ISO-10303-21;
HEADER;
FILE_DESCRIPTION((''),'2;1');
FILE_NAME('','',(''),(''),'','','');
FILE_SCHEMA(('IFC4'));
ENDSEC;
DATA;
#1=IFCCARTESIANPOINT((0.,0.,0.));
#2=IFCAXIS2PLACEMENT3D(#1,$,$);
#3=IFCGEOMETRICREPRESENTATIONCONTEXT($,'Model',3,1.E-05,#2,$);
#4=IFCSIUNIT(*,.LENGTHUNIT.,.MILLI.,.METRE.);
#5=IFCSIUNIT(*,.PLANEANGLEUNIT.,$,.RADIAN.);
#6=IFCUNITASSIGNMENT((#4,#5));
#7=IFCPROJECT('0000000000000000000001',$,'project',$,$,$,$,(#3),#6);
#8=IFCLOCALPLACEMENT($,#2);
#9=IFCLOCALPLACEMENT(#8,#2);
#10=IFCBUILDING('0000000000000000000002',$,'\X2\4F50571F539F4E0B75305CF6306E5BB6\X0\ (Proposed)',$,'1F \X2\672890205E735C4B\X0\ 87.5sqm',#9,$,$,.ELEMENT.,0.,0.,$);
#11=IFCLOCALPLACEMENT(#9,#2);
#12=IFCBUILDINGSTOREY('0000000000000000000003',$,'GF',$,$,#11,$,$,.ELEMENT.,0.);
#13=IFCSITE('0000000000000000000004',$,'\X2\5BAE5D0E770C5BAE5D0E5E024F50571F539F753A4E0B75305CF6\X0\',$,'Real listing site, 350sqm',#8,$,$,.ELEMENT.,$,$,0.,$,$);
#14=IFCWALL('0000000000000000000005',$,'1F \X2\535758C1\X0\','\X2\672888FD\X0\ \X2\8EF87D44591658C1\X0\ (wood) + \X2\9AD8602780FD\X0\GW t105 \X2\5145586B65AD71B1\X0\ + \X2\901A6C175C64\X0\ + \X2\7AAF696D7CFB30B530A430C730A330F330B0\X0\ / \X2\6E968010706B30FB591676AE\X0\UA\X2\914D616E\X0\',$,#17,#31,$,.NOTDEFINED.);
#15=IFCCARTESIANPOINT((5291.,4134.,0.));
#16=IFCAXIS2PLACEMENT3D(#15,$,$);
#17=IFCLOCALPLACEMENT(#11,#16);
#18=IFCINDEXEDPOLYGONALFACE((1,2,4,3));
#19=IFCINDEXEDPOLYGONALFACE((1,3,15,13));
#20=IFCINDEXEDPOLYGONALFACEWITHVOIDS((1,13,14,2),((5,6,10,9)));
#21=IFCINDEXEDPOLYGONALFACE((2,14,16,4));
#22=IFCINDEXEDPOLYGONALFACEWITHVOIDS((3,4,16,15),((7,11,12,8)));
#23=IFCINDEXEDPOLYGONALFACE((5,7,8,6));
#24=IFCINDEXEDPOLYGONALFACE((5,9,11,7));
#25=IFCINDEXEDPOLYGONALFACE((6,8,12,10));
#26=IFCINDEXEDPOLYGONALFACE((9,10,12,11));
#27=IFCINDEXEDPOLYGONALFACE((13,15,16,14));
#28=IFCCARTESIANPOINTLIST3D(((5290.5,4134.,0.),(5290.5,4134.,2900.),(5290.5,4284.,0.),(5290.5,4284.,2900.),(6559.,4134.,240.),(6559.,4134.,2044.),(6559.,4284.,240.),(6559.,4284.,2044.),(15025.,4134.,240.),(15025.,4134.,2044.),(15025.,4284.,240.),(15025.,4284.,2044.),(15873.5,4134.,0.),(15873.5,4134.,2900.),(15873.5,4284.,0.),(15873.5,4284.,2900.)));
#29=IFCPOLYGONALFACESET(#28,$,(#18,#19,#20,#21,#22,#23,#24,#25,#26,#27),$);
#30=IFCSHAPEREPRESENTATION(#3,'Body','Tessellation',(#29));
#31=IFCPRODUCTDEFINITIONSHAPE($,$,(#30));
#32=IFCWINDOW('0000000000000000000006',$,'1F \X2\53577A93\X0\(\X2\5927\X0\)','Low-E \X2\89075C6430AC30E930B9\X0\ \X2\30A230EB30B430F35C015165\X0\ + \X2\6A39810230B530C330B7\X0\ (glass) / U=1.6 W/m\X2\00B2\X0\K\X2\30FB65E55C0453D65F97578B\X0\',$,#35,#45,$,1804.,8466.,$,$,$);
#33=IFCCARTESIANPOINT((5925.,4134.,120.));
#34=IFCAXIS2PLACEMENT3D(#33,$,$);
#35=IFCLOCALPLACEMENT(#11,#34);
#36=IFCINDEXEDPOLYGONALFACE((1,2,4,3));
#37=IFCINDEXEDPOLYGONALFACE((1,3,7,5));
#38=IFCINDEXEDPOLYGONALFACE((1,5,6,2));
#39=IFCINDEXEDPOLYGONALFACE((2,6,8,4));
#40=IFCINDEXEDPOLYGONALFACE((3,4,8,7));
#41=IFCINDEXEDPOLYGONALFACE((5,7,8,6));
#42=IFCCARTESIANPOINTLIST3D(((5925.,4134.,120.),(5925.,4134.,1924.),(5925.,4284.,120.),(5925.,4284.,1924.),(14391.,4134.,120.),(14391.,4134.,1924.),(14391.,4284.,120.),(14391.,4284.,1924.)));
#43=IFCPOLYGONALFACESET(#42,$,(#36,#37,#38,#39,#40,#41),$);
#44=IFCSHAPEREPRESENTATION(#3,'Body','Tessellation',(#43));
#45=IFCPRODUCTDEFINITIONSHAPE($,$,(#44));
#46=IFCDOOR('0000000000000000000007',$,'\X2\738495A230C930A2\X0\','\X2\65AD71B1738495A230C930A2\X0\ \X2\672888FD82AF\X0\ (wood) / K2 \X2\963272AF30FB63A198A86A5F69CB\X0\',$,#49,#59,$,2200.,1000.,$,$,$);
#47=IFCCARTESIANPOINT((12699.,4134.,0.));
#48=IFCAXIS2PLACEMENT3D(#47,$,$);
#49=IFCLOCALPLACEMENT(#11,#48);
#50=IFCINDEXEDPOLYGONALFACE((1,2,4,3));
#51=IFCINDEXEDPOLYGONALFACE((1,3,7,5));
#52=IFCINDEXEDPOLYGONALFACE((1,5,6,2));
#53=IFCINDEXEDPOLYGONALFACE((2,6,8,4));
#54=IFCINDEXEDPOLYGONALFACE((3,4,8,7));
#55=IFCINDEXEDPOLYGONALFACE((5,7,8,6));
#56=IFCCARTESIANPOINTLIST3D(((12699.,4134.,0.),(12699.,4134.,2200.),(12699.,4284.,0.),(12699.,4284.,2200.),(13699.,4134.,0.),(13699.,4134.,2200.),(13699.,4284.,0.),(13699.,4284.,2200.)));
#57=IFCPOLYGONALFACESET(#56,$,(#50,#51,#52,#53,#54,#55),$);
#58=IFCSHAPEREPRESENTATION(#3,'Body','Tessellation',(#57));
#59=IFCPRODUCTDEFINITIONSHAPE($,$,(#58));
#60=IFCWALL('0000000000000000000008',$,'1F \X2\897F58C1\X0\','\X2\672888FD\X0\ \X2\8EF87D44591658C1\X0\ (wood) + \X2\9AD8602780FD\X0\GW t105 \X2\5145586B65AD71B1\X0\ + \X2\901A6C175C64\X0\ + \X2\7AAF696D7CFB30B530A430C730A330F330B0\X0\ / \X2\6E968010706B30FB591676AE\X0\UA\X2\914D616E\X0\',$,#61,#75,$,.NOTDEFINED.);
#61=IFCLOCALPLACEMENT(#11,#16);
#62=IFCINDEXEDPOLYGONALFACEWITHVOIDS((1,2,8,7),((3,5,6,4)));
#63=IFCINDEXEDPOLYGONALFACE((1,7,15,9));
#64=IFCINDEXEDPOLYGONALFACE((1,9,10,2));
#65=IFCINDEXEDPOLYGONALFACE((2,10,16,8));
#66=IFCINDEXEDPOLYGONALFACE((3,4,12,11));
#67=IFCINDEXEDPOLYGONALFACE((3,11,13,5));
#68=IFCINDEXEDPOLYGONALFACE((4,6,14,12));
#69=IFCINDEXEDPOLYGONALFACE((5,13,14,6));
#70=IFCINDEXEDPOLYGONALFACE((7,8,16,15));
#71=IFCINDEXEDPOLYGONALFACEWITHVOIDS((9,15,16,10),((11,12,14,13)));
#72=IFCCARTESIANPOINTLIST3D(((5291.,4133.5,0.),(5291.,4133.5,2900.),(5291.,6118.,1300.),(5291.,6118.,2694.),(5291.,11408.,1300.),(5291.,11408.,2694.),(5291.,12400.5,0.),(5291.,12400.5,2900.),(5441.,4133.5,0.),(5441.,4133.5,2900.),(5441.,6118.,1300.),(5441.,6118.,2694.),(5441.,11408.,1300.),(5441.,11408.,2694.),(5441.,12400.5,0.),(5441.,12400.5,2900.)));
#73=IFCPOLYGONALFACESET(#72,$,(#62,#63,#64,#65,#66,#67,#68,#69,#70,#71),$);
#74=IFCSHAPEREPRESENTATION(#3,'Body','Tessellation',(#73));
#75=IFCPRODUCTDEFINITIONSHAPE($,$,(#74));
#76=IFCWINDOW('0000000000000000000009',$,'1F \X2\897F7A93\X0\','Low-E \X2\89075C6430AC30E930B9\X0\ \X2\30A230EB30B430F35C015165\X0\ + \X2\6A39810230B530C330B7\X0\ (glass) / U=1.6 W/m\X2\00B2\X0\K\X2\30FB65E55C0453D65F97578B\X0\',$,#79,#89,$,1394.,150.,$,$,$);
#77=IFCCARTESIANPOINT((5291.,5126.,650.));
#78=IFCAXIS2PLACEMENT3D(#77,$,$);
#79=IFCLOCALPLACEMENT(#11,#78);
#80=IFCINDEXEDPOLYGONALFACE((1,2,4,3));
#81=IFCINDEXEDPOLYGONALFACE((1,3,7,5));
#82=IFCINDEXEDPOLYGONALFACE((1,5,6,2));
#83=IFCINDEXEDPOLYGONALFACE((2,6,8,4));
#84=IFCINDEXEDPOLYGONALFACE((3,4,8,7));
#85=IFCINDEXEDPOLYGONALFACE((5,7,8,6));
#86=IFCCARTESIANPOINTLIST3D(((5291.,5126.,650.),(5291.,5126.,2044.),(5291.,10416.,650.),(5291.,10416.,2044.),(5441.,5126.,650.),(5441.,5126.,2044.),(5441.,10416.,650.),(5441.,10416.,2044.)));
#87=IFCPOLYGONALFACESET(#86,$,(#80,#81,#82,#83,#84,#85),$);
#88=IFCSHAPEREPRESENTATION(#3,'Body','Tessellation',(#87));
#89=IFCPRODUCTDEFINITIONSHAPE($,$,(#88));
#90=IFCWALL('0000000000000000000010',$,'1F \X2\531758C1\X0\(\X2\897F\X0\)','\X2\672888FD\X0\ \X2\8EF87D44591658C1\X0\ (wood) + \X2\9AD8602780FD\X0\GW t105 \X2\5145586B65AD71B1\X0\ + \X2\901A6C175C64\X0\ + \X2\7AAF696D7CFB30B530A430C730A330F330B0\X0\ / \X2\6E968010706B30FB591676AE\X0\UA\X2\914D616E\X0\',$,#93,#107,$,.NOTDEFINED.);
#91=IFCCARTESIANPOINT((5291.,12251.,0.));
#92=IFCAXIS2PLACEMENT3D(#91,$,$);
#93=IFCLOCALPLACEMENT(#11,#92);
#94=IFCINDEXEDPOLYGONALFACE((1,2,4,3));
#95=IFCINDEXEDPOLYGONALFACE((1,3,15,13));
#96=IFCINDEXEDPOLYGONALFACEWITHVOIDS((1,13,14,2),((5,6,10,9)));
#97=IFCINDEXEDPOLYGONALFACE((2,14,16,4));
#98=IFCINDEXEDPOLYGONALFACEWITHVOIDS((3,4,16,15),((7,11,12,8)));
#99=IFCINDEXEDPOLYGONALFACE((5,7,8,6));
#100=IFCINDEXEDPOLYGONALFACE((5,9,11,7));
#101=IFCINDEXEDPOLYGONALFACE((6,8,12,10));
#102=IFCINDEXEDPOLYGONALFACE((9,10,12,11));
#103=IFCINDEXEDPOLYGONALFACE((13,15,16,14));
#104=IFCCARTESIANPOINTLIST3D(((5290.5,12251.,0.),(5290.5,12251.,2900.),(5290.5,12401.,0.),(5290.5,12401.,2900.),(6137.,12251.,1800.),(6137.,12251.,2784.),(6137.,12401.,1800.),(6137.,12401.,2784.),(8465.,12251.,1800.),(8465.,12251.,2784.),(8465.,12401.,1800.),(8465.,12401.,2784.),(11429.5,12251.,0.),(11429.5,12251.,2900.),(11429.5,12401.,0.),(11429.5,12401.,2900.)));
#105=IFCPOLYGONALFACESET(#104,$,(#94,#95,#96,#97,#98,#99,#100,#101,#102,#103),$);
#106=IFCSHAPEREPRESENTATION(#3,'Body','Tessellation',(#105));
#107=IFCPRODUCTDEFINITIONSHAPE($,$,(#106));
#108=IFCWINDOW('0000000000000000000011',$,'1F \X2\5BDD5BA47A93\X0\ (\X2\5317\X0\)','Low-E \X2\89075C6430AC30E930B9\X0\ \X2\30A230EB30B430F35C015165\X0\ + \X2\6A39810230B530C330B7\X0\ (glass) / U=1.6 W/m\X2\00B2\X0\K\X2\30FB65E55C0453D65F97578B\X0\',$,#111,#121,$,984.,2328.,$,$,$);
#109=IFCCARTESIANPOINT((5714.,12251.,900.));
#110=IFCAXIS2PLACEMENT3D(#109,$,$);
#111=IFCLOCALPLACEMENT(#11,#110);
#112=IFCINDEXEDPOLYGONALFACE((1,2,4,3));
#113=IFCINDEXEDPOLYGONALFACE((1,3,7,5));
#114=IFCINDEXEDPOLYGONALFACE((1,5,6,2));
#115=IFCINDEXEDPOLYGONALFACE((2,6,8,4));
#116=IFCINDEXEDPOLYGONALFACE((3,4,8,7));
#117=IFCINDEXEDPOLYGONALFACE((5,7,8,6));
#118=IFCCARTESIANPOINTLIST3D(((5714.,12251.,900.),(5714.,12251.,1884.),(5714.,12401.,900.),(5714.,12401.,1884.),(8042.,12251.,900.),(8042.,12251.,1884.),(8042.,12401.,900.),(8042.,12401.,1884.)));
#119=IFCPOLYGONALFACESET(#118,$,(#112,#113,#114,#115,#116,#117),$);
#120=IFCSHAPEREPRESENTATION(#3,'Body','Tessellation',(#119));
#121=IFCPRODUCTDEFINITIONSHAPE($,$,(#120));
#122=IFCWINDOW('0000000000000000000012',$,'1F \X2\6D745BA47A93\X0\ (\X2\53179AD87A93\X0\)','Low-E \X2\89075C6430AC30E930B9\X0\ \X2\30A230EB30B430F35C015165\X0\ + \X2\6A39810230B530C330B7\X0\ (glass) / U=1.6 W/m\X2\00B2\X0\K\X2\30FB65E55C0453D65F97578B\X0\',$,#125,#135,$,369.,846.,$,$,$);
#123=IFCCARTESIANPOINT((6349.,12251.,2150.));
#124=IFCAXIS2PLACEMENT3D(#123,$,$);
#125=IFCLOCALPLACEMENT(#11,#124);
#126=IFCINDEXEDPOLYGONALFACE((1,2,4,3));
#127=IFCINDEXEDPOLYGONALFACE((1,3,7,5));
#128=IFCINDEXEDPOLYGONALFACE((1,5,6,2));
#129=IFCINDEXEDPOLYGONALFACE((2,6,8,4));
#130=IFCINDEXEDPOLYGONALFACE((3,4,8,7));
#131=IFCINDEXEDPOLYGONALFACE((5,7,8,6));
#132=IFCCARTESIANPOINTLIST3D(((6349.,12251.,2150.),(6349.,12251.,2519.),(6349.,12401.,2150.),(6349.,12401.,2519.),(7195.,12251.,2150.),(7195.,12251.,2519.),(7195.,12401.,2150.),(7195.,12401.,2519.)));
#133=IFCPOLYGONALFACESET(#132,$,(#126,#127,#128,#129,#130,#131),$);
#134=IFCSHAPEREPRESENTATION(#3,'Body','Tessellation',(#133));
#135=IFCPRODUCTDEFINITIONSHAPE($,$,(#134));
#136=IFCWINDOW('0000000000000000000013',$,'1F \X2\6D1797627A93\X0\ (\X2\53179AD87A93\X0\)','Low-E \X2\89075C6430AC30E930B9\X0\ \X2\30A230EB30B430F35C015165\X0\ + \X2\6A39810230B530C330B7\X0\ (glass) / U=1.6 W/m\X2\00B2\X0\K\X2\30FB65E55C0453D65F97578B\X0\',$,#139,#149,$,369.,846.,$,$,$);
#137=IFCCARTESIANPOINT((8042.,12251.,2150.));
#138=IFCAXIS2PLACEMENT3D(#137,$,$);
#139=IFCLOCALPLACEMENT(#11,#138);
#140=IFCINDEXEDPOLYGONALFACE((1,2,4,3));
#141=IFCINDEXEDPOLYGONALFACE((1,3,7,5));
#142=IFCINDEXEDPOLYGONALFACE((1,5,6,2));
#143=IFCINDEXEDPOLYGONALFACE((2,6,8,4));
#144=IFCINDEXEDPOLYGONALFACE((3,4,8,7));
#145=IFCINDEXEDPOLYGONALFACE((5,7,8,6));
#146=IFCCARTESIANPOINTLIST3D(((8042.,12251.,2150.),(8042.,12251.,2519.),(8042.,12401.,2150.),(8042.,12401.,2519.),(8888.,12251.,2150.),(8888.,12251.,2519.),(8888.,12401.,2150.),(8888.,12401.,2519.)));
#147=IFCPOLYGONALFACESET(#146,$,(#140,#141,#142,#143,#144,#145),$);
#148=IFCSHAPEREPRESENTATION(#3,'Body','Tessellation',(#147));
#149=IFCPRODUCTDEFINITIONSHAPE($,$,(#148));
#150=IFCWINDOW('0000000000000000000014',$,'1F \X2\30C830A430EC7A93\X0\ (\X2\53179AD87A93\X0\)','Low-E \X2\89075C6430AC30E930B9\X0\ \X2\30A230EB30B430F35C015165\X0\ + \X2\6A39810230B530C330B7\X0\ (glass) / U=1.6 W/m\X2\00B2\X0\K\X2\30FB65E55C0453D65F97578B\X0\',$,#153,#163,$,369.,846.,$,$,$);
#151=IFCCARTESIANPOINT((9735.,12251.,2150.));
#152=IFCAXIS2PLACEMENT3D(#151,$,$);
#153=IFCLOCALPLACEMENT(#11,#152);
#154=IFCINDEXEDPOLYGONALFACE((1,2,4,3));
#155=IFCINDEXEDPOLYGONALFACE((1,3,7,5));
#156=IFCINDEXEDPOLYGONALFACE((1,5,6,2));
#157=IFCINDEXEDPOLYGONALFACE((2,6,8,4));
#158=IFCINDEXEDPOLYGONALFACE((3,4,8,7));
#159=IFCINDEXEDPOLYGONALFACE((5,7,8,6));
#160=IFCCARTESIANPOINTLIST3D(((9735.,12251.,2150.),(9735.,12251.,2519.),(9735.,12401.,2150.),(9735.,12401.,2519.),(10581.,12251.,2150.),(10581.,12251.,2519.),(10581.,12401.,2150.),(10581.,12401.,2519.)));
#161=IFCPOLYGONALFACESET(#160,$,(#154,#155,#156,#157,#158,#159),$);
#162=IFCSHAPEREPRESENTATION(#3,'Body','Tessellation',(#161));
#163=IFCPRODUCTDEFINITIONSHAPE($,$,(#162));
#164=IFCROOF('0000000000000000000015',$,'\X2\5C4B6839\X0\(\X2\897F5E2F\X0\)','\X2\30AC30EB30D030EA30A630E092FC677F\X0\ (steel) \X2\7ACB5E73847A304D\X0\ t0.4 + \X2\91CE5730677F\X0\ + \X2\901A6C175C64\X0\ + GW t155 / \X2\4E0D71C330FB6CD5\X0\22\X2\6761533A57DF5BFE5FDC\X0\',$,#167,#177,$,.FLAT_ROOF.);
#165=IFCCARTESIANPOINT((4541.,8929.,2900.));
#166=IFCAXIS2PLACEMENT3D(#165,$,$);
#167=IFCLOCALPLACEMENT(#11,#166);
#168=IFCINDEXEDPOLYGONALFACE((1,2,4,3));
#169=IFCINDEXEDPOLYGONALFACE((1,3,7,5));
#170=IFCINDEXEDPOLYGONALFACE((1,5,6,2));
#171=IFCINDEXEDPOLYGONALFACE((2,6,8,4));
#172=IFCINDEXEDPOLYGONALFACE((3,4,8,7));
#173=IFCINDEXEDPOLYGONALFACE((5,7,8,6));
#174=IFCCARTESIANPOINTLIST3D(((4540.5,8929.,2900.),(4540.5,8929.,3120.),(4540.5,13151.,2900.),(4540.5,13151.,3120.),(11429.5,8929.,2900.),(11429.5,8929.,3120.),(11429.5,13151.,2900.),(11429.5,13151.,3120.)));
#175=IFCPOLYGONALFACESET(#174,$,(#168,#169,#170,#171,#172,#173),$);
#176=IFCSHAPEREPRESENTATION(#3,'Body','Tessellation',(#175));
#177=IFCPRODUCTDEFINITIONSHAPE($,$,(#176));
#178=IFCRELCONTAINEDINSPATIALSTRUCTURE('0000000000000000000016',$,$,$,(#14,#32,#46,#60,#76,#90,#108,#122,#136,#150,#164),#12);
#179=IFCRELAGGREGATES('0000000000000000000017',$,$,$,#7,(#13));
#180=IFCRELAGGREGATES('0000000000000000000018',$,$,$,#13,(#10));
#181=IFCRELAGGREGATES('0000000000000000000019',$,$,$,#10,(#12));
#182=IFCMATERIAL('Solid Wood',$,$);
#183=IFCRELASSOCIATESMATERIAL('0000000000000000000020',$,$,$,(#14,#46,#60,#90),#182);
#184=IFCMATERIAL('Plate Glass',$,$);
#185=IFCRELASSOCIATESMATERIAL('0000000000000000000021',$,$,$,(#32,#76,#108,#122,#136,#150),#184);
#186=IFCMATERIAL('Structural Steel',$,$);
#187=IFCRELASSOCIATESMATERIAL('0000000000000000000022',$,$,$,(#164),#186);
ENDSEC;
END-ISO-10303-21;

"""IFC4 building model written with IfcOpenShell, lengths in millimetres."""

from ifc_helpers import new_model, si_unit, frame, frame_2d, origin, place, context, project, spatial, rectangle, extrude, material, element, fill, save


model = new_model("IFC4")

# Units and contexts
model_context = context("Model", 3, precision=1e-05, world=origin())
ifc_project = project(units=[si_unit("LENGTHUNIT", "METRE", prefix="MILLI"), si_unit("PLANEANGLEUNIT", "RADIAN")], contexts=[model_context])

# Site, building, storey
site_placement = place(None, origin())
site = spatial("IfcSite", under=ifc_project, at=site_placement, Name="宮崎県宮崎市佐土原町下田島", ObjectType="Real listing site, 350sqm", CompositionType="ELEMENT", RefElevation=0.0)
building_placement = place(site_placement, origin())
building = spatial("IfcBuilding", under=site, at=building_placement, Name="佐土原下田島の家 (Proposed)", ObjectType="1F 木造平屋 87.5sqm", CompositionType="ELEMENT", ElevationOfRefHeight=0.0, ElevationOfTerrain=0.0)
storey_placement = place(building_placement, origin())
storey = spatial("IfcBuildingStorey", under=building, at=storey_placement, Name="GF", CompositionType="ELEMENT", Elevation=0.0)

# Shared definitions
ifc_material_1 = material(Name="Solid Wood")

# Wall, openings, window, door
wall_1_placement = place(storey_placement, frame((5291.0, 4134.0, 0.0)))
wall_1 = element("IfcWall", 1, at=wall_1_placement, inside=storey, material=ifc_material_1, Name="1F 南壁", Description="木製 軸組外壁 (wood) + 高性能GW t105 充填断熱 + 通気層 + 窯業系サイディング / 準耐火・外皮UA配慮", PredefinedType="NOTDEFINED", context=model_context, shape_type="SweptSolid", body=[
    extrude(rectangle(XDim=10583.0, YDim=150.0, at=frame_2d((5291.0, 75.0))), frame((5291.0, 4134.0, 0.0)), (0.0, 0.0, 1.0), 2900.0),
])
opening_1_placement = place(storey_placement, frame((5925.0, 4134.0, 120.0)))
opening_1 = element("IfcOpeningElement", 2, at=opening_1_placement, cuts=wall_1, PredefinedType="NOTDEFINED", context=model_context, shape_type="SweptSolid", body=[
    extrude(rectangle(XDim=8466.0, YDim=150.0, at=frame_2d((4233.0, 75.0))), frame((5925.0, 4134.0, 120.0)), (0.0, 0.0, 1.0), 1804.0),
])
opening_2_placement = place(storey_placement, frame((12699.0, 4134.0, 0.0)))
opening_2 = element("IfcOpeningElement", 3, at=opening_2_placement, cuts=wall_1, PredefinedType="NOTDEFINED", context=model_context, shape_type="SweptSolid", body=[
    extrude(rectangle(XDim=1000.0, YDim=150.0, at=frame_2d((500.0, 75.0))), frame((12699.0, 4134.0, 0.0)), (0.0, 0.0, 1.0), 2200.0),
])
ifc_material_2 = material(Name="Plate Glass")
window_1_placement = place(storey_placement, frame((5925.0, 4134.0, 120.0)))
window_1 = element("IfcWindow", 4, at=window_1_placement, inside=storey, material=ifc_material_2, Name="1F 南窓(大)", Description="Low-E 複層ガラス アルゴン封入 + 樹脂サッシ (glass) / U=1.6 W/m²K・日射取得型", OverallHeight=1804.0, OverallWidth=8466.0, context=model_context, shape_type="SweptSolid", body=[
    extrude(rectangle(XDim=8466.0, YDim=150.0, at=frame_2d((4233.0, 75.0))), frame((5925.0, 4134.0, 120.0)), (0.0, 0.0, 1.0), 1804.0),
])
fill(opening_1, window_1)
door_1_placement = place(storey_placement, frame((12699.0, 4134.0, 0.0)))
door_1 = element("IfcDoor", 5, at=door_1_placement, inside=storey, material=ifc_material_1, Name="玄関ドア", Description="断熱玄関ドア 木製芯 (wood) / K2 防犯・採風機構", OverallHeight=2200.0, OverallWidth=1000.0, context=model_context, shape_type="SweptSolid", body=[
    extrude(rectangle(XDim=1000.0, YDim=150.0, at=frame_2d((500.0, 75.0))), frame((12699.0, 4134.0, 0.0)), (0.0, 0.0, 1.0), 2200.0),
])
fill(opening_2, door_1)

# Wall, opening, window
wall_2_placement = place(storey_placement, frame((5291.0, 4134.0, 0.0)))
wall_2 = element("IfcWall", 6, at=wall_2_placement, inside=storey, material=ifc_material_1, Name="1F 西壁", Description="木製 軸組外壁 (wood) + 高性能GW t105 充填断熱 + 通気層 + 窯業系サイディング / 準耐火・外皮UA配慮", PredefinedType="NOTDEFINED", context=model_context, shape_type="SweptSolid", body=[
    extrude(rectangle(XDim=150.0, YDim=8267.0, at=frame_2d((75.0, 4133.0))), frame((5291.0, 4134.0, 0.0)), (0.0, 0.0, 1.0), 2900.0),
])
opening_3_placement = place(storey_placement, frame((5291.0, 5126.0, 650.0)))
opening_3 = element("IfcOpeningElement", 7, at=opening_3_placement, cuts=wall_2, PredefinedType="NOTDEFINED", context=model_context, shape_type="SweptSolid", body=[
    extrude(rectangle(XDim=150.0, YDim=5290.0, at=frame_2d((75.0, 2645.0))), frame((5291.0, 5126.0, 650.0)), (0.0, 0.0, 1.0), 1394.0),
])
window_2_placement = place(storey_placement, frame((5291.0, 5126.0, 650.0)))
window_2 = element("IfcWindow", 8, at=window_2_placement, inside=storey, material=ifc_material_2, Name="1F 西窓", Description="Low-E 複層ガラス アルゴン封入 + 樹脂サッシ (glass) / U=1.6 W/m²K・日射取得型", OverallHeight=1394.0, OverallWidth=150.0, context=model_context, shape_type="SweptSolid", body=[
    extrude(rectangle(XDim=150.0, YDim=5290.0, at=frame_2d((75.0, 2645.0))), frame((5291.0, 5126.0, 650.0)), (0.0, 0.0, 1.0), 1394.0),
])
fill(opening_3, window_2)

# Wall, openings, windows
wall_3_placement = place(storey_placement, frame((5291.0, 12251.0, 0.0)))
wall_3 = element("IfcWall", 9, at=wall_3_placement, inside=storey, material=ifc_material_1, Name="1F 北壁(西)", Description="木製 軸組外壁 (wood) + 高性能GW t105 充填断熱 + 通気層 + 窯業系サイディング / 準耐火・外皮UA配慮", PredefinedType="NOTDEFINED", context=model_context, shape_type="SweptSolid", body=[
    extrude(rectangle(XDim=6139.0, YDim=150.0, at=frame_2d((3069.0, 75.0))), frame((5291.0, 12251.0, 0.0)), (0.0, 0.0, 1.0), 2900.0),
])
opening_4_placement = place(storey_placement, frame((5714.0, 12251.0, 900.0)))
opening_4 = element("IfcOpeningElement", 10, at=opening_4_placement, cuts=wall_3, PredefinedType="NOTDEFINED", context=model_context, shape_type="SweptSolid", body=[
    extrude(rectangle(XDim=2328.0, YDim=150.0, at=frame_2d((1164.0, 75.0))), frame((5714.0, 12251.0, 900.0)), (0.0, 0.0, 1.0), 984.0),
])
opening_5_placement = place(storey_placement, frame((6349.0, 12251.0, 2150.0)))
opening_5 = element("IfcOpeningElement", 11, at=opening_5_placement, cuts=wall_3, PredefinedType="NOTDEFINED", context=model_context, shape_type="SweptSolid", body=[
    extrude(rectangle(XDim=846.0, YDim=150.0, at=frame_2d((423.0, 75.0))), frame((6349.0, 12251.0, 2150.0)), (0.0, 0.0, 1.0), 369.0),
])
opening_6_placement = place(storey_placement, frame((8042.0, 12251.0, 2150.0)))
opening_6 = element("IfcOpeningElement", 12, at=opening_6_placement, cuts=wall_3, PredefinedType="NOTDEFINED", context=model_context, shape_type="SweptSolid", body=[
    extrude(rectangle(XDim=846.0, YDim=150.0, at=frame_2d((423.0, 75.0))), frame((8042.0, 12251.0, 2150.0)), (0.0, 0.0, 1.0), 369.0),
])
opening_7_placement = place(storey_placement, frame((9735.0, 12251.0, 2150.0)))
opening_7 = element("IfcOpeningElement", 13, at=opening_7_placement, cuts=wall_3, PredefinedType="NOTDEFINED", context=model_context, shape_type="SweptSolid", body=[
    extrude(rectangle(XDim=846.0, YDim=150.0, at=frame_2d((423.0, 75.0))), frame((9735.0, 12251.0, 2150.0)), (0.0, 0.0, 1.0), 369.0),
])
window_3_placement = place(storey_placement, frame((5714.0, 12251.0, 900.0)))
window_3 = element("IfcWindow", 14, at=window_3_placement, inside=storey, material=ifc_material_2, Name="1F 寝室窓 (北)", Description="Low-E 複層ガラス アルゴン封入 + 樹脂サッシ (glass) / U=1.6 W/m²K・日射取得型", OverallHeight=984.0, OverallWidth=2328.0, context=model_context, shape_type="SweptSolid", body=[
    extrude(rectangle(XDim=2328.0, YDim=150.0, at=frame_2d((1164.0, 75.0))), frame((5714.0, 12251.0, 900.0)), (0.0, 0.0, 1.0), 984.0),
])
fill(opening_4, window_3)
window_4_placement = place(storey_placement, frame((6349.0, 12251.0, 2150.0)))
window_4 = element("IfcWindow", 15, at=window_4_placement, inside=storey, material=ifc_material_2, Name="1F 浴室窓 (北高窓)", Description="Low-E 複層ガラス アルゴン封入 + 樹脂サッシ (glass) / U=1.6 W/m²K・日射取得型", OverallHeight=369.0, OverallWidth=846.0, context=model_context, shape_type="SweptSolid", body=[
    extrude(rectangle(XDim=846.0, YDim=150.0, at=frame_2d((423.0, 75.0))), frame((6349.0, 12251.0, 2150.0)), (0.0, 0.0, 1.0), 369.0),
])
fill(opening_5, window_4)
window_5_placement = place(storey_placement, frame((8042.0, 12251.0, 2150.0)))
window_5 = element("IfcWindow", 16, at=window_5_placement, inside=storey, material=ifc_material_2, Name="1F 洗面窓 (北高窓)", Description="Low-E 複層ガラス アルゴン封入 + 樹脂サッシ (glass) / U=1.6 W/m²K・日射取得型", OverallHeight=369.0, OverallWidth=846.0, context=model_context, shape_type="SweptSolid", body=[
    extrude(rectangle(XDim=846.0, YDim=150.0, at=frame_2d((423.0, 75.0))), frame((8042.0, 12251.0, 2150.0)), (0.0, 0.0, 1.0), 369.0),
])
fill(opening_6, window_5)
window_6_placement = place(storey_placement, frame((9735.0, 12251.0, 2150.0)))
window_6 = element("IfcWindow", 17, at=window_6_placement, inside=storey, material=ifc_material_2, Name="1F トイレ窓 (北高窓)", Description="Low-E 複層ガラス アルゴン封入 + 樹脂サッシ (glass) / U=1.6 W/m²K・日射取得型", OverallHeight=369.0, OverallWidth=846.0, context=model_context, shape_type="SweptSolid", body=[
    extrude(rectangle(XDim=846.0, YDim=150.0, at=frame_2d((423.0, 75.0))), frame((9735.0, 12251.0, 2150.0)), (0.0, 0.0, 1.0), 369.0),
])
fill(opening_7, window_6)

# Roof
ifc_material_3 = material(Name="Structural Steel")
roof_1_placement = place(storey_placement, frame((4541.0, 8929.0, 2900.0)))
element("IfcRoof", 18, at=roof_1_placement, inside=storey, material=ifc_material_3, Name="屋根(西帯)", Description="ガルバリウム鋼板 (steel) 立平葺き t0.4 + 野地板 + 通気層 + GW t155 / 不燃・法22条区域対応", PredefinedType="FLAT_ROOF", context=model_context, shape_type="SweptSolid", body=[
    extrude(rectangle(XDim=6889.0, YDim=4222.0, at=frame_2d((3444.0, 2111.0))), frame((4541.0, 8929.0, 2900.0)), (0.0, 0.0, 1.0), 220.0),
])

save(model, "model.ifc")
